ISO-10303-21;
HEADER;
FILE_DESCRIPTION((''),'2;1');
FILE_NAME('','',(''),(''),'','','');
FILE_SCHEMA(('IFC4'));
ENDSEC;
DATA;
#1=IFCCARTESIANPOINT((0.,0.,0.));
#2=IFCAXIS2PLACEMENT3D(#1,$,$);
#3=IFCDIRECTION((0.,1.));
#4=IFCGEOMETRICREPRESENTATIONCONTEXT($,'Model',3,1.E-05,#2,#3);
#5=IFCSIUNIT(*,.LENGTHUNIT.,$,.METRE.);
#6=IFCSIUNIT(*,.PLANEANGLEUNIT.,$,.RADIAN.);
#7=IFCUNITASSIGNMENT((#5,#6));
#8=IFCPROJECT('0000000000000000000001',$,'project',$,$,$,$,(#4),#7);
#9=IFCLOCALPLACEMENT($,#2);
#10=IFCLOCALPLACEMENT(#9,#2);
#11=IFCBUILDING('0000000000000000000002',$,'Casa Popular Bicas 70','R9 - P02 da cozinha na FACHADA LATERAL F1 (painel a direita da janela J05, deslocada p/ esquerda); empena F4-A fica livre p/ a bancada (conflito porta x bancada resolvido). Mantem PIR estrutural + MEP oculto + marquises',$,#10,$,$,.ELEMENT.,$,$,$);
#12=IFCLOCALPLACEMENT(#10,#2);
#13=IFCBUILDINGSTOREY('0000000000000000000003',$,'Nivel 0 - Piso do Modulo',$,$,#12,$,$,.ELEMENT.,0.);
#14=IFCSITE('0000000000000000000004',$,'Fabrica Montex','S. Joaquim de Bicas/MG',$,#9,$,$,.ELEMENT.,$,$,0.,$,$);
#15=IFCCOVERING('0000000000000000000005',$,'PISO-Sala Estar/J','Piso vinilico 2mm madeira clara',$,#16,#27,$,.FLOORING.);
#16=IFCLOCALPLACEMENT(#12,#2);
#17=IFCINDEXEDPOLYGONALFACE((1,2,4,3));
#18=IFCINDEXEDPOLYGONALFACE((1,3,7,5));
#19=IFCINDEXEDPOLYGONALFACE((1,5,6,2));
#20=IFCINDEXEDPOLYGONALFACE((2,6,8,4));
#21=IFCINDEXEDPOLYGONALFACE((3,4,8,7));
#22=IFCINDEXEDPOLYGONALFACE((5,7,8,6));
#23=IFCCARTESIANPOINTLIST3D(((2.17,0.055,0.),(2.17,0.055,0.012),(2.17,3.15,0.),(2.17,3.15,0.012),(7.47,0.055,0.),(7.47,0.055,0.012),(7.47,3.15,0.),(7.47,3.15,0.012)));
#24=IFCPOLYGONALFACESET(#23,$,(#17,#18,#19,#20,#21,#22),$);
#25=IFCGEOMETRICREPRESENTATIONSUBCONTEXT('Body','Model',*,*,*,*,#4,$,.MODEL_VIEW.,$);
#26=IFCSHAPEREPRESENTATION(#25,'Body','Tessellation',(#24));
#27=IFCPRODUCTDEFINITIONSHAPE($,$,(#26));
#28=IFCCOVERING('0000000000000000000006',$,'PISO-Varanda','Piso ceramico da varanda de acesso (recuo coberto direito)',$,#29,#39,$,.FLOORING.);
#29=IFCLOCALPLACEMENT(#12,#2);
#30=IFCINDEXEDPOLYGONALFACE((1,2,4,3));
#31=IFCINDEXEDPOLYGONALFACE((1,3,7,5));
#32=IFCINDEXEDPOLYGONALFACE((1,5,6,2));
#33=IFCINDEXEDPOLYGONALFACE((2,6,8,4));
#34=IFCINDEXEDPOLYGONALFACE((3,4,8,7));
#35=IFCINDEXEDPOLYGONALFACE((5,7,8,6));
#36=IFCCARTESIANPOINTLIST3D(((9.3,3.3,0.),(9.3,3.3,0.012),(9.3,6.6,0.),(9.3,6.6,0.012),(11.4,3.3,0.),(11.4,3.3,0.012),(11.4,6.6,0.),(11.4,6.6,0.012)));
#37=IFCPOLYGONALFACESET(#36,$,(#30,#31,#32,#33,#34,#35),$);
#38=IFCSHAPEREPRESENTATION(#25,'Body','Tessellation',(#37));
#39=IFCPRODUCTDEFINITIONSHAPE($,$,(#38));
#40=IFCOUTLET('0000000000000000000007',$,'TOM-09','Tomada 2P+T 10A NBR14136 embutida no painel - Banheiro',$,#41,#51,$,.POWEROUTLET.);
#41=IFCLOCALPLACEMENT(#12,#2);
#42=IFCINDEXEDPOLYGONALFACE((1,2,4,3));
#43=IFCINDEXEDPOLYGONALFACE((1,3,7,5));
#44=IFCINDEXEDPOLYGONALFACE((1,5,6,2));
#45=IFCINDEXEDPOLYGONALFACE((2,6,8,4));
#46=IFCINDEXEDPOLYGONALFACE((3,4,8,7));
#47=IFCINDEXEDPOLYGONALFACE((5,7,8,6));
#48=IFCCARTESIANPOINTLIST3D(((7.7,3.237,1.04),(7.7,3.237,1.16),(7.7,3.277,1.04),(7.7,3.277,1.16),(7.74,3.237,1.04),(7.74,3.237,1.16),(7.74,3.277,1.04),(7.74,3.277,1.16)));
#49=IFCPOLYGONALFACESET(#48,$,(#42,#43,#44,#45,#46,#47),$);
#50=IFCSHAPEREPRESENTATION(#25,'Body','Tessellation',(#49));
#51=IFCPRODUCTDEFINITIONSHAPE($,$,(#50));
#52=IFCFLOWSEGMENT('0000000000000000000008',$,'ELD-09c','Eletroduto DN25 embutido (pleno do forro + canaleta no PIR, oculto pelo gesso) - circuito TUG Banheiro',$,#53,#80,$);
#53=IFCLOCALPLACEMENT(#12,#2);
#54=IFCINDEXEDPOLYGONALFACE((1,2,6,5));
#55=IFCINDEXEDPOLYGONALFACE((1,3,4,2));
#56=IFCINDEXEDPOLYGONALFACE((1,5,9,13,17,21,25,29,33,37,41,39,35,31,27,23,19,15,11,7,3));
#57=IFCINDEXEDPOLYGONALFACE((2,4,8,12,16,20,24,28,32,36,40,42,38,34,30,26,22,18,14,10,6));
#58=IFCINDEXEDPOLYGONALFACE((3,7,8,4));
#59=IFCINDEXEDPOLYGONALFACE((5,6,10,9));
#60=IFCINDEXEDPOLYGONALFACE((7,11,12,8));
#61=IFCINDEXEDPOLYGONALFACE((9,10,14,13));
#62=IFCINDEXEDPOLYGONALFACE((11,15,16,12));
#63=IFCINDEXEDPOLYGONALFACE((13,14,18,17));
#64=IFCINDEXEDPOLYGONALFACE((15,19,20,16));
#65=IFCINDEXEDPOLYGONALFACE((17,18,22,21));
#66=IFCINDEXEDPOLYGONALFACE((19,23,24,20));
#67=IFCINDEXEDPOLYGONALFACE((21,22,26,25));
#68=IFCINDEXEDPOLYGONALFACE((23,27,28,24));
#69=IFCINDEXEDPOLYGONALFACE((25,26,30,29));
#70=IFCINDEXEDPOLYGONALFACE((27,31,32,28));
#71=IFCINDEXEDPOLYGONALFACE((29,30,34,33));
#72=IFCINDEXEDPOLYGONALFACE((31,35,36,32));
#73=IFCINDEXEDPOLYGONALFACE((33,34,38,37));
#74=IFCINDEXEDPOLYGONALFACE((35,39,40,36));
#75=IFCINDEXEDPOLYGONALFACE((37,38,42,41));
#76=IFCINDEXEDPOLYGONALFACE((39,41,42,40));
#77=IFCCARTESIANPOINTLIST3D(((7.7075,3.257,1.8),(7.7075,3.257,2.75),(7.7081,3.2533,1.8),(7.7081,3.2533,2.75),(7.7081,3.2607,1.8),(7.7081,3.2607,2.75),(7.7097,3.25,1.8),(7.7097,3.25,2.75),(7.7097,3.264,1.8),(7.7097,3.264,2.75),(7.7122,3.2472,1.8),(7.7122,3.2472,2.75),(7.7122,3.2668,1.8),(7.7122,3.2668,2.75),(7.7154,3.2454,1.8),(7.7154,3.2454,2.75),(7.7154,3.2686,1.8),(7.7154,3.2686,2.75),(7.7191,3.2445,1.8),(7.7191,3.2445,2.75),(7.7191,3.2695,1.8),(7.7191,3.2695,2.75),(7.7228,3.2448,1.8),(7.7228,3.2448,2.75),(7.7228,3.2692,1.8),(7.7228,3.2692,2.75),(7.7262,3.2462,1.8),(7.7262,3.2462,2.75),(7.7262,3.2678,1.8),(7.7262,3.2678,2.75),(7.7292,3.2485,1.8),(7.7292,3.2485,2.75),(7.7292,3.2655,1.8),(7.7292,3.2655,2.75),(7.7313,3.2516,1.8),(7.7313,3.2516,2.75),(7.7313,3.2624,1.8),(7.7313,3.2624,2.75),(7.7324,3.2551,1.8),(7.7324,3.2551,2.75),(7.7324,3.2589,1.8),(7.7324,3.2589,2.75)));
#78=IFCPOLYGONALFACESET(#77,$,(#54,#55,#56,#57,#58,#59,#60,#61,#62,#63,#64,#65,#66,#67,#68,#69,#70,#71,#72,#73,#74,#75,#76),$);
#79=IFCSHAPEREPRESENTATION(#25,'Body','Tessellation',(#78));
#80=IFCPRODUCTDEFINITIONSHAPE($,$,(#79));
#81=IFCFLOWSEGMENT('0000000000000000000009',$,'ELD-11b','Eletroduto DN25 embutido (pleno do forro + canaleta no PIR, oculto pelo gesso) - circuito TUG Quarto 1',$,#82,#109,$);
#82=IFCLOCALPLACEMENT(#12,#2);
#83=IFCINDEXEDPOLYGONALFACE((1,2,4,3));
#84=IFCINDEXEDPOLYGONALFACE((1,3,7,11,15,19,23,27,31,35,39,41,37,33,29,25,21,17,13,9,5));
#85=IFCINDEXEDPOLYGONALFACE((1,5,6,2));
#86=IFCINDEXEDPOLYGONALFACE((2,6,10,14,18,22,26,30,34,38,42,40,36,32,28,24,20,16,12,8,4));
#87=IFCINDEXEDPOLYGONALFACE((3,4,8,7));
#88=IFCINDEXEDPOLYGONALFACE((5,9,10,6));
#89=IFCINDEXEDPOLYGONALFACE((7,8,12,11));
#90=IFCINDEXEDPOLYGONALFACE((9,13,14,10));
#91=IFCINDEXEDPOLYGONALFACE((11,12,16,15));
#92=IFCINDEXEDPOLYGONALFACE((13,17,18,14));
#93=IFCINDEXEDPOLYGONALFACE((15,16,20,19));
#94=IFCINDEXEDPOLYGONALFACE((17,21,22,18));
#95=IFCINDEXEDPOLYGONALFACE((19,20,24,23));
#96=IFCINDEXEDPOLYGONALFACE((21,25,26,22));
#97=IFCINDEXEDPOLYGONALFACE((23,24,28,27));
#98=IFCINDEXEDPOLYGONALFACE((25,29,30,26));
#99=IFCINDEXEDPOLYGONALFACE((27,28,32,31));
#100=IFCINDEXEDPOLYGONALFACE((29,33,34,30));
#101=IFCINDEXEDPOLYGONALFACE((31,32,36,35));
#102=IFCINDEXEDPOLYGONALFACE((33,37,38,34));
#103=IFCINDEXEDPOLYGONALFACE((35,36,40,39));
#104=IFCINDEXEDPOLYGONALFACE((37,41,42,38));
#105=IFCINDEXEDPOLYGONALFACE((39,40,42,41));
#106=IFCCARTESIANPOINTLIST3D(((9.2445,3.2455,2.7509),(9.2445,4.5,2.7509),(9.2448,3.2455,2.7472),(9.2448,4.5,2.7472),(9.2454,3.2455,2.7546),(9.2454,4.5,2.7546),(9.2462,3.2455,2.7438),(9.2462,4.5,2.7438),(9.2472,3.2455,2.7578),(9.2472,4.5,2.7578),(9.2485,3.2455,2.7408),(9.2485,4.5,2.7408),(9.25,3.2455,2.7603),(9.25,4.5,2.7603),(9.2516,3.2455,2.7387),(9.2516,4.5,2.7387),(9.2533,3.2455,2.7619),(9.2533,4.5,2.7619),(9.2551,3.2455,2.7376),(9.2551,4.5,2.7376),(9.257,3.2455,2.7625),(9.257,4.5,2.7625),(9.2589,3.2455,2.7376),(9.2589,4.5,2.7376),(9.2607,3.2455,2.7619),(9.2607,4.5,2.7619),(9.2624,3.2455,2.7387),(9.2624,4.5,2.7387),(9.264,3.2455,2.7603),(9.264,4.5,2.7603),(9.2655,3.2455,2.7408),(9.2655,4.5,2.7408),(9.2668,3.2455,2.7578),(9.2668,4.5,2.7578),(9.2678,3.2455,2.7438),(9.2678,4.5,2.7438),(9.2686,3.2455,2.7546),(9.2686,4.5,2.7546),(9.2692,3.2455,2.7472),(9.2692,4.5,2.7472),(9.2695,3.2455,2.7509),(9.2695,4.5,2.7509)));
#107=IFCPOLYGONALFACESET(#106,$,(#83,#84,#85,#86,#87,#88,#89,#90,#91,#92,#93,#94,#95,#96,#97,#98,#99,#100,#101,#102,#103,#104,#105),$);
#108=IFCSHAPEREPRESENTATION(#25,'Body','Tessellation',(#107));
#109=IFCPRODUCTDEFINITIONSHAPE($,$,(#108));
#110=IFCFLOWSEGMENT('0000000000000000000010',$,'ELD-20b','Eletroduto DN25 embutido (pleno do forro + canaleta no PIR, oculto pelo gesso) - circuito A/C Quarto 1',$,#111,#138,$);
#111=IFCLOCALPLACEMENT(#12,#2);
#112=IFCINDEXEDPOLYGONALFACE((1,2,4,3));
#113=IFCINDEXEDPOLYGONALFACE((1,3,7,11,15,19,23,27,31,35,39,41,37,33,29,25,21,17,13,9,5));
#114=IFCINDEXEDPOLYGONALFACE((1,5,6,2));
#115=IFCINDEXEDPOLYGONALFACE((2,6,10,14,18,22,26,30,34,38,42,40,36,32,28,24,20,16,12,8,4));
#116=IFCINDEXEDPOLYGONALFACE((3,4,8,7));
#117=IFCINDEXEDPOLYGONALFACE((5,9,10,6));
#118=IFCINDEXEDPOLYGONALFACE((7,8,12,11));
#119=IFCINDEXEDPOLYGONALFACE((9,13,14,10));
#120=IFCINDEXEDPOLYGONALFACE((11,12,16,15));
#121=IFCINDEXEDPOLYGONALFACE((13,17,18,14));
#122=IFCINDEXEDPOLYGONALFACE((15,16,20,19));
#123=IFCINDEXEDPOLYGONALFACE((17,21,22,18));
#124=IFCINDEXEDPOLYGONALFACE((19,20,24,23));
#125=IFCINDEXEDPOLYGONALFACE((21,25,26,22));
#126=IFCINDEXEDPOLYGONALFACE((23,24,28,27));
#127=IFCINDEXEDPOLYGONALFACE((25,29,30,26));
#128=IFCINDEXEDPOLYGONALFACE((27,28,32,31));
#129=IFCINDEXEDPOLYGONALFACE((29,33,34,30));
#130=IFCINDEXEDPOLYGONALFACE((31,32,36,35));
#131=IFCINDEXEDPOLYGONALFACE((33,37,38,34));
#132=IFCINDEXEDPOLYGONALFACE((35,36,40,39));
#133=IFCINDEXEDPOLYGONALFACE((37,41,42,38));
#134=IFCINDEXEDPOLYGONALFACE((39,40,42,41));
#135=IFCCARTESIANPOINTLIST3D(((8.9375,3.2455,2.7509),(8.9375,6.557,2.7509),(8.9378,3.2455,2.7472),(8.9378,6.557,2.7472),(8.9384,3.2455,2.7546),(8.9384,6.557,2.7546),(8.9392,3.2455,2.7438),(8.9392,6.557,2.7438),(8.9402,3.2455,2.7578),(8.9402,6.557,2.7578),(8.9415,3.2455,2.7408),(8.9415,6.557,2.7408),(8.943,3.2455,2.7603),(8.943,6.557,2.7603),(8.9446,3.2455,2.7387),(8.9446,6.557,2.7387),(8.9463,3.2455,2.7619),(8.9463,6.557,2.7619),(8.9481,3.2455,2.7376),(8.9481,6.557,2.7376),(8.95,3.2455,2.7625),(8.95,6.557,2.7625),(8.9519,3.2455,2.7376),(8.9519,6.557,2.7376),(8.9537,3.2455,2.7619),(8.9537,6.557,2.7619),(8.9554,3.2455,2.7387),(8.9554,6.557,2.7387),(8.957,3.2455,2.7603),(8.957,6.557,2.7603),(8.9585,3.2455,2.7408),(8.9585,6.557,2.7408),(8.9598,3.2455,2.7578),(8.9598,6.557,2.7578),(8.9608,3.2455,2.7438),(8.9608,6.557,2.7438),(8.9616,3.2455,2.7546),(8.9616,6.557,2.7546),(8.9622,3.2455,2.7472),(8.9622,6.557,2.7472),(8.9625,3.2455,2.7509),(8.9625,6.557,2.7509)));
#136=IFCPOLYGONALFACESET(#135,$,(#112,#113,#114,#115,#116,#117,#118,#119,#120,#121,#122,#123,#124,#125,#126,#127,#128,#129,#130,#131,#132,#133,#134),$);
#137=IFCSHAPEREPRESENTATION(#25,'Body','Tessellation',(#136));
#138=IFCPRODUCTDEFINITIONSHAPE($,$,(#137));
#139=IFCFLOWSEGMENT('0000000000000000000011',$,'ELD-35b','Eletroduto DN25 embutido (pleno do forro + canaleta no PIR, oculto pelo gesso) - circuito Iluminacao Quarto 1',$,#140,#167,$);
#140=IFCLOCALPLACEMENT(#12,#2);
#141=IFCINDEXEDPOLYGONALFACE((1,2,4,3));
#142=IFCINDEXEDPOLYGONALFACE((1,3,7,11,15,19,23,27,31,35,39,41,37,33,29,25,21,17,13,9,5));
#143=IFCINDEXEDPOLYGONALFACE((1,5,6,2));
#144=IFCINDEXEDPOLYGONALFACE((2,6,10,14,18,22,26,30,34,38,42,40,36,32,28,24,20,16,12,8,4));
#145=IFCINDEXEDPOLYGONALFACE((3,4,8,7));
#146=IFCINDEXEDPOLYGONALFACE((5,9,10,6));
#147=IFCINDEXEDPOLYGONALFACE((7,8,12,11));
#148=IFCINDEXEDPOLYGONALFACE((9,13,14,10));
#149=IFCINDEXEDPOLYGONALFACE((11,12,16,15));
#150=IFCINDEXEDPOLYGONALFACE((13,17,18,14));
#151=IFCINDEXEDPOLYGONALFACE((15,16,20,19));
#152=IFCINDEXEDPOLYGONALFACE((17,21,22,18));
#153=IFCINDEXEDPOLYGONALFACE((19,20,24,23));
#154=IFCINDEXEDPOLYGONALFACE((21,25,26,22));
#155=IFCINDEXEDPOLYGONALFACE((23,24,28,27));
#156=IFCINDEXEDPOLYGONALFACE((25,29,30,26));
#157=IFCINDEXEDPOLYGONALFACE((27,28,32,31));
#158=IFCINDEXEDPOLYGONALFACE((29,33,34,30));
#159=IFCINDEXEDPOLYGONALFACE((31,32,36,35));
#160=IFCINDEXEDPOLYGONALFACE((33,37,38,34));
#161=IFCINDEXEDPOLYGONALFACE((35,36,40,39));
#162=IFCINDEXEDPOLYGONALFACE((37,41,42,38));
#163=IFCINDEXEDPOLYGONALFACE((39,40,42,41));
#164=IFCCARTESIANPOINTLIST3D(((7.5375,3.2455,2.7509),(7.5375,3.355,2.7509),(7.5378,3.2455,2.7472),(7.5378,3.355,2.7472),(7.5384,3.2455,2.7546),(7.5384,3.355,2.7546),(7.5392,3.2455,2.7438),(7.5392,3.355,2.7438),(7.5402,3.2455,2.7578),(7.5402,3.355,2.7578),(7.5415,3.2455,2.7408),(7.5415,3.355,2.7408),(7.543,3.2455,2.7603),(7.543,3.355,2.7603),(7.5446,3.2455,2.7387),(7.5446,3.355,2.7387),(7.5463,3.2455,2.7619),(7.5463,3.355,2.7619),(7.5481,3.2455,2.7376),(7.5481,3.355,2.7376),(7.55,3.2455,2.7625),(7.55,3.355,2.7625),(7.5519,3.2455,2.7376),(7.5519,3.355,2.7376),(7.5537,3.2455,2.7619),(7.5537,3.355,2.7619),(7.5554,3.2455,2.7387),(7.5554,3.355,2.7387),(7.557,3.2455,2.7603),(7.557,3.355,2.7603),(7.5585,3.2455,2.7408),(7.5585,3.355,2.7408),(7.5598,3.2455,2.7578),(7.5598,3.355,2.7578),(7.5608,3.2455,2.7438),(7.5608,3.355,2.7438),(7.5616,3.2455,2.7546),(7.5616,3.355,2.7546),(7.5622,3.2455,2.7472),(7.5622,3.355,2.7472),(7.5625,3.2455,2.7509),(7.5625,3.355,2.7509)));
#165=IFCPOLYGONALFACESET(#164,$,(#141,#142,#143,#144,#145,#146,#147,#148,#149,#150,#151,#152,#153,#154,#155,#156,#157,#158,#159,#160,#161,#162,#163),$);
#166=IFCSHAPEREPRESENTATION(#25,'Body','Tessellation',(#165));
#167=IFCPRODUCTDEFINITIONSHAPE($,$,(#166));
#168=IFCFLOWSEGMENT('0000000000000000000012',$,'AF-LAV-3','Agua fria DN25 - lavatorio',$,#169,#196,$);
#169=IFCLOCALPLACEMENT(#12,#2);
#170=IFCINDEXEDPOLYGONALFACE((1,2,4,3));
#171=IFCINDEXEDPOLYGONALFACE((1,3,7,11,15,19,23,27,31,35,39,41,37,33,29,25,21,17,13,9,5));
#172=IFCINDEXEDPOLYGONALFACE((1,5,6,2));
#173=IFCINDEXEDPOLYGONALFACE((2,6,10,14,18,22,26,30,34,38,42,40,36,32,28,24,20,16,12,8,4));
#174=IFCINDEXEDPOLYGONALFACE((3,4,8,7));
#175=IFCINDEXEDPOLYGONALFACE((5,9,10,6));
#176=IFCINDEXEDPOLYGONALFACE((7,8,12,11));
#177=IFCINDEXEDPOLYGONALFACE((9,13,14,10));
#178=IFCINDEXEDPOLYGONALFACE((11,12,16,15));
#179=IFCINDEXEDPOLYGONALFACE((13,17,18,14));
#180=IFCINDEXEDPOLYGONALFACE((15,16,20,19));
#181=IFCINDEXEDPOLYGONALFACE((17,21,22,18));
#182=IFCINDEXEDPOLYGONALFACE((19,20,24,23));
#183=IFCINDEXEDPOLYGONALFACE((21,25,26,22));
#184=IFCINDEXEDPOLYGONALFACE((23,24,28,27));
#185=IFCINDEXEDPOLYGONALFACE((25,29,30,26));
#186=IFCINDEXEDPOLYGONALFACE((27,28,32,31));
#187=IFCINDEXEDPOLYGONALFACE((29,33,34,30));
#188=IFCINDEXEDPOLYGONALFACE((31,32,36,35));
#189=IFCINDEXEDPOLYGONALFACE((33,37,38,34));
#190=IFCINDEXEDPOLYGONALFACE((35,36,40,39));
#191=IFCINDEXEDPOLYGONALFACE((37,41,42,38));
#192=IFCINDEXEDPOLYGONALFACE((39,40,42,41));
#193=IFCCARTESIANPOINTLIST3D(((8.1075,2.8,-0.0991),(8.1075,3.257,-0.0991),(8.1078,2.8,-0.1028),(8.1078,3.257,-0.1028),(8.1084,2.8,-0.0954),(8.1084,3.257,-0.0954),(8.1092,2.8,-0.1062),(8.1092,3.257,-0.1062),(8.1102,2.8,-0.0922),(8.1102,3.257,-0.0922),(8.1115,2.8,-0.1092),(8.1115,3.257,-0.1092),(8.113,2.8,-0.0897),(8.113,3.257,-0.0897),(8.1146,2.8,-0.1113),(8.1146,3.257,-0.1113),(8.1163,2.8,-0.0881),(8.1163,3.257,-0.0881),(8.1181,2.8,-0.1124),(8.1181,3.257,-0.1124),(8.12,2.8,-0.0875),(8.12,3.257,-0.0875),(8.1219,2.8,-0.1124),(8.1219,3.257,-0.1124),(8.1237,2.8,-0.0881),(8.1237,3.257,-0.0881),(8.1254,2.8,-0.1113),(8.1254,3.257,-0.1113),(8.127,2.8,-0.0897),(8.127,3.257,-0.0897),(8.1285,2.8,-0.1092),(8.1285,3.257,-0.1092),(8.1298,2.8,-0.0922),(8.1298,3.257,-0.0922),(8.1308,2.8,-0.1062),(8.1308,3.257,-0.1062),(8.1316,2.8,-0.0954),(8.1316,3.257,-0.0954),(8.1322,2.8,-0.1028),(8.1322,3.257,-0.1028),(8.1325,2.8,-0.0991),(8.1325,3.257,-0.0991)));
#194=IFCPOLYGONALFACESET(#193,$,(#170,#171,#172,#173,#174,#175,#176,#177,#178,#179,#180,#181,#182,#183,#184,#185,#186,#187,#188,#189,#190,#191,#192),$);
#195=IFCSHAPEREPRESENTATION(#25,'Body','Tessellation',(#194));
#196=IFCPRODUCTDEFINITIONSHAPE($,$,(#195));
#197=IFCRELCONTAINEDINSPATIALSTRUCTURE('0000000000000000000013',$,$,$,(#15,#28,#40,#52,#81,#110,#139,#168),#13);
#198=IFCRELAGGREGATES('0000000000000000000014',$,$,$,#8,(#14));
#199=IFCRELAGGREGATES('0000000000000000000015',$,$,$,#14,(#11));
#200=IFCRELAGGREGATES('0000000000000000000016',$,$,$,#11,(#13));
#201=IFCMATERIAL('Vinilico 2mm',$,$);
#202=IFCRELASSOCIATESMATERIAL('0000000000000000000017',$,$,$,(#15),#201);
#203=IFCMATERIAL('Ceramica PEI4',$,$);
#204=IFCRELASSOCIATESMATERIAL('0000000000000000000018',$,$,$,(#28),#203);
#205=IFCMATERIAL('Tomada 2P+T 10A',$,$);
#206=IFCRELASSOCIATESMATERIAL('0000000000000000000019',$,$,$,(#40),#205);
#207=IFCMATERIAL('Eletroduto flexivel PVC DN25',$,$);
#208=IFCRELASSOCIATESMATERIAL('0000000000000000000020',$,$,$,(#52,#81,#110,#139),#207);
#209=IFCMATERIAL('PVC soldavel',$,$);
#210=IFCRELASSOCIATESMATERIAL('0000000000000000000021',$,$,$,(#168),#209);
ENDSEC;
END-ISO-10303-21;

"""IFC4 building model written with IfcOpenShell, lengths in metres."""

from ifc_helpers import new_model, si_unit, direction, frame, frame_2d, origin, origin_2d, place, context, subcontext, project, spatial, rectangle, circle, extrude, material, element, save


model = new_model("IFC4")

# Units and contexts
model_context = context("Model", 3, precision=1e-05, world=origin(), true_north=direction((0.0, 1.0)))
body_context = subcontext(model_context, "Body", "Model", "MODEL_VIEW")
ifc_project = project(units=[si_unit("LENGTHUNIT", "METRE"), si_unit("PLANEANGLEUNIT", "RADIAN")], contexts=[model_context])

# Site, building, storey
site_placement = place(None, origin())
site = spatial("IfcSite", under=ifc_project, at=site_placement, Name="Fabrica Montex", Description="S. Joaquim de Bicas/MG", CompositionType="ELEMENT", RefElevation=0.0)
building_placement = place(site_placement, origin())
building = spatial("IfcBuilding", under=site, at=building_placement, Name="Casa Popular Bicas 70", Description="R9 - P02 da cozinha na FACHADA LATERAL F1 (painel a direita da janela J05, deslocada p/ esquerda); empena F4-A fica livre p/ a bancada (conflito porta x bancada resolvido). Mantem PIR estrutural + MEP oculto + marquises", CompositionType="ELEMENT")
storey_placement = place(building_placement, origin())
storey = spatial("IfcBuildingStorey", under=building, at=storey_placement, Name="Nivel 0 - Piso do Modulo", CompositionType="ELEMENT", Elevation=0.0)

# Coverings
ifc_material_1 = material(Name="Vinilico 2mm")
covering_1_placement = place(None, frame((7.47, 3.15, 0.0), z_axis=(0.0, 0.0, 1.0), x_axis=(-1.0, 0.0, 0.0)))
element("IfcCovering", 1, at=covering_1_placement, inside=storey, material=ifc_material_1, Name="PISO-Sala Estar/J", Description="Piso vinilico 2mm madeira clara", PredefinedType="FLOORING", context=body_context, shape_type="SweptSolid", body=[
    extrude(rectangle(XDim=5.3, YDim=3.095, at=frame_2d((2.65, 1.5475))), origin(), (0.0, 0.0, 1.0), 0.012),
])
ifc_material_2 = material(Name="Ceramica PEI4")
covering_2_placement = place(storey_placement, frame((9.3, 3.3, 0.0)))
element("IfcCovering", 2, at=covering_2_placement, inside=storey, material=ifc_material_2, Name="PISO-Varanda", Description="Piso ceramico da varanda de acesso (recuo coberto direito)", PredefinedType="FLOORING", context=body_context, shape_type="SweptSolid", body=[
    extrude(rectangle(XDim=2.1, YDim=3.3, at=frame_2d((1.05, 1.65))), origin(), (0.0, 0.0, 1.0), 0.012),
])

# Outlet
ifc_material_3 = material(Name="Tomada 2P+T 10A")
outlet_placement = place(None, frame((7.74, 3.277, 1.04), z_axis=(0.0, 0.0, 1.0), x_axis=(-1.0, 0.0, 0.0)))
element("IfcOutlet", 3, at=outlet_placement, inside=storey, material=ifc_material_3, Name="TOM-09", Description="Tomada 2P+T 10A NBR14136 embutida no painel - Banheiro", PredefinedType="POWEROUTLET", context=body_context, shape_type="SweptSolid", body=[
    extrude(rectangle(XDim=0.04, YDim=0.04, at=frame_2d((0.02, 0.02))), origin(), (0.0, 0.0, 1.0), 0.12),
])

# Flow segments
ifc_material_4 = material(Name="Eletroduto flexivel PVC DN25")
flow_segment_1_placement = place(None, frame((7.72, 3.257, 2.75), z_axis=(0.0, 0.0, -1.0), x_axis=(-1.0, 0.0, 0.0)))
element("IfcFlowSegment", 4, at=flow_segment_1_placement, inside=storey, material=ifc_material_4, Name="ELD-09c", Description="Eletroduto DN25 embutido (pleno do forro + canaleta no PIR, oculto pelo gesso) - circuito TUG Banheiro", context=body_context, shape_type="SweptSolid", body=[
    extrude(circle(Radius=0.0125, at=origin_2d()), origin(), (0.0, 0.0, 1.0), 0.95),
])
flow_segment_2_placement = place(storey_placement, frame((9.257, 3.2455, 2.75), z_axis=(0.0, 1.0, 0.0), x_axis=(0.0, 0.0, 1.0)))
element("IfcFlowSegment", 5, at=flow_segment_2_placement, inside=storey, material=ifc_material_4, Name="ELD-11b", Description="Eletroduto DN25 embutido (pleno do forro + canaleta no PIR, oculto pelo gesso) - circuito TUG Quarto 1", context=body_context, shape_type="SweptSolid", body=[
    extrude(circle(Radius=0.0125, at=origin_2d()), origin(), (0.0, 0.0, 1.0), 1.2545),
])
flow_segment_3_placement = place(storey_placement, frame((8.95, 3.2455, 2.75), z_axis=(0.0, 1.0, 0.0), x_axis=(0.0, 0.0, 1.0)))
element("IfcFlowSegment", 6, at=flow_segment_3_placement, inside=storey, material=ifc_material_4, Name="ELD-20b", Description="Eletroduto DN25 embutido (pleno do forro + canaleta no PIR, oculto pelo gesso) - circuito A/C Quarto 1", context=body_context, shape_type="SweptSolid", body=[
    extrude(circle(Radius=0.0125, at=origin_2d()), origin(), (0.0, 0.0, 1.0), 3.3115),
])
flow_segment_4_placement = place(storey_placement, frame((7.55, 3.2455, 2.75), z_axis=(0.0, 1.0, 0.0), x_axis=(0.0, 0.0, 1.0)))
element("IfcFlowSegment", 7, at=flow_segment_4_placement, inside=storey, material=ifc_material_4, Name="ELD-35b", Description="Eletroduto DN25 embutido (pleno do forro + canaleta no PIR, oculto pelo gesso) - circuito Iluminacao Quarto 1", context=body_context, shape_type="SweptSolid", body=[
    extrude(circle(Radius=0.0125, at=origin_2d()), origin(), (0.0, 0.0, 1.0), 0.1095),
])
ifc_material_5 = material(Name="PVC soldavel")
flow_segment_5_placement = place(None, frame((8.12, 2.8, -0.1), z_axis=(0.0, 1.0, 0.0), x_axis=(0.0, 0.0, 1.0)))
element("IfcFlowSegment", 8, at=flow_segment_5_placement, inside=storey, material=ifc_material_5, Name="AF-LAV-3", Description="Agua fria DN25 - lavatorio", context=body_context, shape_type="SweptSolid", body=[
    extrude(circle(Radius=0.0125, at=origin_2d()), origin(), (0.0, 0.0, 1.0), 0.457),
])

save(model, "model.ifc")
